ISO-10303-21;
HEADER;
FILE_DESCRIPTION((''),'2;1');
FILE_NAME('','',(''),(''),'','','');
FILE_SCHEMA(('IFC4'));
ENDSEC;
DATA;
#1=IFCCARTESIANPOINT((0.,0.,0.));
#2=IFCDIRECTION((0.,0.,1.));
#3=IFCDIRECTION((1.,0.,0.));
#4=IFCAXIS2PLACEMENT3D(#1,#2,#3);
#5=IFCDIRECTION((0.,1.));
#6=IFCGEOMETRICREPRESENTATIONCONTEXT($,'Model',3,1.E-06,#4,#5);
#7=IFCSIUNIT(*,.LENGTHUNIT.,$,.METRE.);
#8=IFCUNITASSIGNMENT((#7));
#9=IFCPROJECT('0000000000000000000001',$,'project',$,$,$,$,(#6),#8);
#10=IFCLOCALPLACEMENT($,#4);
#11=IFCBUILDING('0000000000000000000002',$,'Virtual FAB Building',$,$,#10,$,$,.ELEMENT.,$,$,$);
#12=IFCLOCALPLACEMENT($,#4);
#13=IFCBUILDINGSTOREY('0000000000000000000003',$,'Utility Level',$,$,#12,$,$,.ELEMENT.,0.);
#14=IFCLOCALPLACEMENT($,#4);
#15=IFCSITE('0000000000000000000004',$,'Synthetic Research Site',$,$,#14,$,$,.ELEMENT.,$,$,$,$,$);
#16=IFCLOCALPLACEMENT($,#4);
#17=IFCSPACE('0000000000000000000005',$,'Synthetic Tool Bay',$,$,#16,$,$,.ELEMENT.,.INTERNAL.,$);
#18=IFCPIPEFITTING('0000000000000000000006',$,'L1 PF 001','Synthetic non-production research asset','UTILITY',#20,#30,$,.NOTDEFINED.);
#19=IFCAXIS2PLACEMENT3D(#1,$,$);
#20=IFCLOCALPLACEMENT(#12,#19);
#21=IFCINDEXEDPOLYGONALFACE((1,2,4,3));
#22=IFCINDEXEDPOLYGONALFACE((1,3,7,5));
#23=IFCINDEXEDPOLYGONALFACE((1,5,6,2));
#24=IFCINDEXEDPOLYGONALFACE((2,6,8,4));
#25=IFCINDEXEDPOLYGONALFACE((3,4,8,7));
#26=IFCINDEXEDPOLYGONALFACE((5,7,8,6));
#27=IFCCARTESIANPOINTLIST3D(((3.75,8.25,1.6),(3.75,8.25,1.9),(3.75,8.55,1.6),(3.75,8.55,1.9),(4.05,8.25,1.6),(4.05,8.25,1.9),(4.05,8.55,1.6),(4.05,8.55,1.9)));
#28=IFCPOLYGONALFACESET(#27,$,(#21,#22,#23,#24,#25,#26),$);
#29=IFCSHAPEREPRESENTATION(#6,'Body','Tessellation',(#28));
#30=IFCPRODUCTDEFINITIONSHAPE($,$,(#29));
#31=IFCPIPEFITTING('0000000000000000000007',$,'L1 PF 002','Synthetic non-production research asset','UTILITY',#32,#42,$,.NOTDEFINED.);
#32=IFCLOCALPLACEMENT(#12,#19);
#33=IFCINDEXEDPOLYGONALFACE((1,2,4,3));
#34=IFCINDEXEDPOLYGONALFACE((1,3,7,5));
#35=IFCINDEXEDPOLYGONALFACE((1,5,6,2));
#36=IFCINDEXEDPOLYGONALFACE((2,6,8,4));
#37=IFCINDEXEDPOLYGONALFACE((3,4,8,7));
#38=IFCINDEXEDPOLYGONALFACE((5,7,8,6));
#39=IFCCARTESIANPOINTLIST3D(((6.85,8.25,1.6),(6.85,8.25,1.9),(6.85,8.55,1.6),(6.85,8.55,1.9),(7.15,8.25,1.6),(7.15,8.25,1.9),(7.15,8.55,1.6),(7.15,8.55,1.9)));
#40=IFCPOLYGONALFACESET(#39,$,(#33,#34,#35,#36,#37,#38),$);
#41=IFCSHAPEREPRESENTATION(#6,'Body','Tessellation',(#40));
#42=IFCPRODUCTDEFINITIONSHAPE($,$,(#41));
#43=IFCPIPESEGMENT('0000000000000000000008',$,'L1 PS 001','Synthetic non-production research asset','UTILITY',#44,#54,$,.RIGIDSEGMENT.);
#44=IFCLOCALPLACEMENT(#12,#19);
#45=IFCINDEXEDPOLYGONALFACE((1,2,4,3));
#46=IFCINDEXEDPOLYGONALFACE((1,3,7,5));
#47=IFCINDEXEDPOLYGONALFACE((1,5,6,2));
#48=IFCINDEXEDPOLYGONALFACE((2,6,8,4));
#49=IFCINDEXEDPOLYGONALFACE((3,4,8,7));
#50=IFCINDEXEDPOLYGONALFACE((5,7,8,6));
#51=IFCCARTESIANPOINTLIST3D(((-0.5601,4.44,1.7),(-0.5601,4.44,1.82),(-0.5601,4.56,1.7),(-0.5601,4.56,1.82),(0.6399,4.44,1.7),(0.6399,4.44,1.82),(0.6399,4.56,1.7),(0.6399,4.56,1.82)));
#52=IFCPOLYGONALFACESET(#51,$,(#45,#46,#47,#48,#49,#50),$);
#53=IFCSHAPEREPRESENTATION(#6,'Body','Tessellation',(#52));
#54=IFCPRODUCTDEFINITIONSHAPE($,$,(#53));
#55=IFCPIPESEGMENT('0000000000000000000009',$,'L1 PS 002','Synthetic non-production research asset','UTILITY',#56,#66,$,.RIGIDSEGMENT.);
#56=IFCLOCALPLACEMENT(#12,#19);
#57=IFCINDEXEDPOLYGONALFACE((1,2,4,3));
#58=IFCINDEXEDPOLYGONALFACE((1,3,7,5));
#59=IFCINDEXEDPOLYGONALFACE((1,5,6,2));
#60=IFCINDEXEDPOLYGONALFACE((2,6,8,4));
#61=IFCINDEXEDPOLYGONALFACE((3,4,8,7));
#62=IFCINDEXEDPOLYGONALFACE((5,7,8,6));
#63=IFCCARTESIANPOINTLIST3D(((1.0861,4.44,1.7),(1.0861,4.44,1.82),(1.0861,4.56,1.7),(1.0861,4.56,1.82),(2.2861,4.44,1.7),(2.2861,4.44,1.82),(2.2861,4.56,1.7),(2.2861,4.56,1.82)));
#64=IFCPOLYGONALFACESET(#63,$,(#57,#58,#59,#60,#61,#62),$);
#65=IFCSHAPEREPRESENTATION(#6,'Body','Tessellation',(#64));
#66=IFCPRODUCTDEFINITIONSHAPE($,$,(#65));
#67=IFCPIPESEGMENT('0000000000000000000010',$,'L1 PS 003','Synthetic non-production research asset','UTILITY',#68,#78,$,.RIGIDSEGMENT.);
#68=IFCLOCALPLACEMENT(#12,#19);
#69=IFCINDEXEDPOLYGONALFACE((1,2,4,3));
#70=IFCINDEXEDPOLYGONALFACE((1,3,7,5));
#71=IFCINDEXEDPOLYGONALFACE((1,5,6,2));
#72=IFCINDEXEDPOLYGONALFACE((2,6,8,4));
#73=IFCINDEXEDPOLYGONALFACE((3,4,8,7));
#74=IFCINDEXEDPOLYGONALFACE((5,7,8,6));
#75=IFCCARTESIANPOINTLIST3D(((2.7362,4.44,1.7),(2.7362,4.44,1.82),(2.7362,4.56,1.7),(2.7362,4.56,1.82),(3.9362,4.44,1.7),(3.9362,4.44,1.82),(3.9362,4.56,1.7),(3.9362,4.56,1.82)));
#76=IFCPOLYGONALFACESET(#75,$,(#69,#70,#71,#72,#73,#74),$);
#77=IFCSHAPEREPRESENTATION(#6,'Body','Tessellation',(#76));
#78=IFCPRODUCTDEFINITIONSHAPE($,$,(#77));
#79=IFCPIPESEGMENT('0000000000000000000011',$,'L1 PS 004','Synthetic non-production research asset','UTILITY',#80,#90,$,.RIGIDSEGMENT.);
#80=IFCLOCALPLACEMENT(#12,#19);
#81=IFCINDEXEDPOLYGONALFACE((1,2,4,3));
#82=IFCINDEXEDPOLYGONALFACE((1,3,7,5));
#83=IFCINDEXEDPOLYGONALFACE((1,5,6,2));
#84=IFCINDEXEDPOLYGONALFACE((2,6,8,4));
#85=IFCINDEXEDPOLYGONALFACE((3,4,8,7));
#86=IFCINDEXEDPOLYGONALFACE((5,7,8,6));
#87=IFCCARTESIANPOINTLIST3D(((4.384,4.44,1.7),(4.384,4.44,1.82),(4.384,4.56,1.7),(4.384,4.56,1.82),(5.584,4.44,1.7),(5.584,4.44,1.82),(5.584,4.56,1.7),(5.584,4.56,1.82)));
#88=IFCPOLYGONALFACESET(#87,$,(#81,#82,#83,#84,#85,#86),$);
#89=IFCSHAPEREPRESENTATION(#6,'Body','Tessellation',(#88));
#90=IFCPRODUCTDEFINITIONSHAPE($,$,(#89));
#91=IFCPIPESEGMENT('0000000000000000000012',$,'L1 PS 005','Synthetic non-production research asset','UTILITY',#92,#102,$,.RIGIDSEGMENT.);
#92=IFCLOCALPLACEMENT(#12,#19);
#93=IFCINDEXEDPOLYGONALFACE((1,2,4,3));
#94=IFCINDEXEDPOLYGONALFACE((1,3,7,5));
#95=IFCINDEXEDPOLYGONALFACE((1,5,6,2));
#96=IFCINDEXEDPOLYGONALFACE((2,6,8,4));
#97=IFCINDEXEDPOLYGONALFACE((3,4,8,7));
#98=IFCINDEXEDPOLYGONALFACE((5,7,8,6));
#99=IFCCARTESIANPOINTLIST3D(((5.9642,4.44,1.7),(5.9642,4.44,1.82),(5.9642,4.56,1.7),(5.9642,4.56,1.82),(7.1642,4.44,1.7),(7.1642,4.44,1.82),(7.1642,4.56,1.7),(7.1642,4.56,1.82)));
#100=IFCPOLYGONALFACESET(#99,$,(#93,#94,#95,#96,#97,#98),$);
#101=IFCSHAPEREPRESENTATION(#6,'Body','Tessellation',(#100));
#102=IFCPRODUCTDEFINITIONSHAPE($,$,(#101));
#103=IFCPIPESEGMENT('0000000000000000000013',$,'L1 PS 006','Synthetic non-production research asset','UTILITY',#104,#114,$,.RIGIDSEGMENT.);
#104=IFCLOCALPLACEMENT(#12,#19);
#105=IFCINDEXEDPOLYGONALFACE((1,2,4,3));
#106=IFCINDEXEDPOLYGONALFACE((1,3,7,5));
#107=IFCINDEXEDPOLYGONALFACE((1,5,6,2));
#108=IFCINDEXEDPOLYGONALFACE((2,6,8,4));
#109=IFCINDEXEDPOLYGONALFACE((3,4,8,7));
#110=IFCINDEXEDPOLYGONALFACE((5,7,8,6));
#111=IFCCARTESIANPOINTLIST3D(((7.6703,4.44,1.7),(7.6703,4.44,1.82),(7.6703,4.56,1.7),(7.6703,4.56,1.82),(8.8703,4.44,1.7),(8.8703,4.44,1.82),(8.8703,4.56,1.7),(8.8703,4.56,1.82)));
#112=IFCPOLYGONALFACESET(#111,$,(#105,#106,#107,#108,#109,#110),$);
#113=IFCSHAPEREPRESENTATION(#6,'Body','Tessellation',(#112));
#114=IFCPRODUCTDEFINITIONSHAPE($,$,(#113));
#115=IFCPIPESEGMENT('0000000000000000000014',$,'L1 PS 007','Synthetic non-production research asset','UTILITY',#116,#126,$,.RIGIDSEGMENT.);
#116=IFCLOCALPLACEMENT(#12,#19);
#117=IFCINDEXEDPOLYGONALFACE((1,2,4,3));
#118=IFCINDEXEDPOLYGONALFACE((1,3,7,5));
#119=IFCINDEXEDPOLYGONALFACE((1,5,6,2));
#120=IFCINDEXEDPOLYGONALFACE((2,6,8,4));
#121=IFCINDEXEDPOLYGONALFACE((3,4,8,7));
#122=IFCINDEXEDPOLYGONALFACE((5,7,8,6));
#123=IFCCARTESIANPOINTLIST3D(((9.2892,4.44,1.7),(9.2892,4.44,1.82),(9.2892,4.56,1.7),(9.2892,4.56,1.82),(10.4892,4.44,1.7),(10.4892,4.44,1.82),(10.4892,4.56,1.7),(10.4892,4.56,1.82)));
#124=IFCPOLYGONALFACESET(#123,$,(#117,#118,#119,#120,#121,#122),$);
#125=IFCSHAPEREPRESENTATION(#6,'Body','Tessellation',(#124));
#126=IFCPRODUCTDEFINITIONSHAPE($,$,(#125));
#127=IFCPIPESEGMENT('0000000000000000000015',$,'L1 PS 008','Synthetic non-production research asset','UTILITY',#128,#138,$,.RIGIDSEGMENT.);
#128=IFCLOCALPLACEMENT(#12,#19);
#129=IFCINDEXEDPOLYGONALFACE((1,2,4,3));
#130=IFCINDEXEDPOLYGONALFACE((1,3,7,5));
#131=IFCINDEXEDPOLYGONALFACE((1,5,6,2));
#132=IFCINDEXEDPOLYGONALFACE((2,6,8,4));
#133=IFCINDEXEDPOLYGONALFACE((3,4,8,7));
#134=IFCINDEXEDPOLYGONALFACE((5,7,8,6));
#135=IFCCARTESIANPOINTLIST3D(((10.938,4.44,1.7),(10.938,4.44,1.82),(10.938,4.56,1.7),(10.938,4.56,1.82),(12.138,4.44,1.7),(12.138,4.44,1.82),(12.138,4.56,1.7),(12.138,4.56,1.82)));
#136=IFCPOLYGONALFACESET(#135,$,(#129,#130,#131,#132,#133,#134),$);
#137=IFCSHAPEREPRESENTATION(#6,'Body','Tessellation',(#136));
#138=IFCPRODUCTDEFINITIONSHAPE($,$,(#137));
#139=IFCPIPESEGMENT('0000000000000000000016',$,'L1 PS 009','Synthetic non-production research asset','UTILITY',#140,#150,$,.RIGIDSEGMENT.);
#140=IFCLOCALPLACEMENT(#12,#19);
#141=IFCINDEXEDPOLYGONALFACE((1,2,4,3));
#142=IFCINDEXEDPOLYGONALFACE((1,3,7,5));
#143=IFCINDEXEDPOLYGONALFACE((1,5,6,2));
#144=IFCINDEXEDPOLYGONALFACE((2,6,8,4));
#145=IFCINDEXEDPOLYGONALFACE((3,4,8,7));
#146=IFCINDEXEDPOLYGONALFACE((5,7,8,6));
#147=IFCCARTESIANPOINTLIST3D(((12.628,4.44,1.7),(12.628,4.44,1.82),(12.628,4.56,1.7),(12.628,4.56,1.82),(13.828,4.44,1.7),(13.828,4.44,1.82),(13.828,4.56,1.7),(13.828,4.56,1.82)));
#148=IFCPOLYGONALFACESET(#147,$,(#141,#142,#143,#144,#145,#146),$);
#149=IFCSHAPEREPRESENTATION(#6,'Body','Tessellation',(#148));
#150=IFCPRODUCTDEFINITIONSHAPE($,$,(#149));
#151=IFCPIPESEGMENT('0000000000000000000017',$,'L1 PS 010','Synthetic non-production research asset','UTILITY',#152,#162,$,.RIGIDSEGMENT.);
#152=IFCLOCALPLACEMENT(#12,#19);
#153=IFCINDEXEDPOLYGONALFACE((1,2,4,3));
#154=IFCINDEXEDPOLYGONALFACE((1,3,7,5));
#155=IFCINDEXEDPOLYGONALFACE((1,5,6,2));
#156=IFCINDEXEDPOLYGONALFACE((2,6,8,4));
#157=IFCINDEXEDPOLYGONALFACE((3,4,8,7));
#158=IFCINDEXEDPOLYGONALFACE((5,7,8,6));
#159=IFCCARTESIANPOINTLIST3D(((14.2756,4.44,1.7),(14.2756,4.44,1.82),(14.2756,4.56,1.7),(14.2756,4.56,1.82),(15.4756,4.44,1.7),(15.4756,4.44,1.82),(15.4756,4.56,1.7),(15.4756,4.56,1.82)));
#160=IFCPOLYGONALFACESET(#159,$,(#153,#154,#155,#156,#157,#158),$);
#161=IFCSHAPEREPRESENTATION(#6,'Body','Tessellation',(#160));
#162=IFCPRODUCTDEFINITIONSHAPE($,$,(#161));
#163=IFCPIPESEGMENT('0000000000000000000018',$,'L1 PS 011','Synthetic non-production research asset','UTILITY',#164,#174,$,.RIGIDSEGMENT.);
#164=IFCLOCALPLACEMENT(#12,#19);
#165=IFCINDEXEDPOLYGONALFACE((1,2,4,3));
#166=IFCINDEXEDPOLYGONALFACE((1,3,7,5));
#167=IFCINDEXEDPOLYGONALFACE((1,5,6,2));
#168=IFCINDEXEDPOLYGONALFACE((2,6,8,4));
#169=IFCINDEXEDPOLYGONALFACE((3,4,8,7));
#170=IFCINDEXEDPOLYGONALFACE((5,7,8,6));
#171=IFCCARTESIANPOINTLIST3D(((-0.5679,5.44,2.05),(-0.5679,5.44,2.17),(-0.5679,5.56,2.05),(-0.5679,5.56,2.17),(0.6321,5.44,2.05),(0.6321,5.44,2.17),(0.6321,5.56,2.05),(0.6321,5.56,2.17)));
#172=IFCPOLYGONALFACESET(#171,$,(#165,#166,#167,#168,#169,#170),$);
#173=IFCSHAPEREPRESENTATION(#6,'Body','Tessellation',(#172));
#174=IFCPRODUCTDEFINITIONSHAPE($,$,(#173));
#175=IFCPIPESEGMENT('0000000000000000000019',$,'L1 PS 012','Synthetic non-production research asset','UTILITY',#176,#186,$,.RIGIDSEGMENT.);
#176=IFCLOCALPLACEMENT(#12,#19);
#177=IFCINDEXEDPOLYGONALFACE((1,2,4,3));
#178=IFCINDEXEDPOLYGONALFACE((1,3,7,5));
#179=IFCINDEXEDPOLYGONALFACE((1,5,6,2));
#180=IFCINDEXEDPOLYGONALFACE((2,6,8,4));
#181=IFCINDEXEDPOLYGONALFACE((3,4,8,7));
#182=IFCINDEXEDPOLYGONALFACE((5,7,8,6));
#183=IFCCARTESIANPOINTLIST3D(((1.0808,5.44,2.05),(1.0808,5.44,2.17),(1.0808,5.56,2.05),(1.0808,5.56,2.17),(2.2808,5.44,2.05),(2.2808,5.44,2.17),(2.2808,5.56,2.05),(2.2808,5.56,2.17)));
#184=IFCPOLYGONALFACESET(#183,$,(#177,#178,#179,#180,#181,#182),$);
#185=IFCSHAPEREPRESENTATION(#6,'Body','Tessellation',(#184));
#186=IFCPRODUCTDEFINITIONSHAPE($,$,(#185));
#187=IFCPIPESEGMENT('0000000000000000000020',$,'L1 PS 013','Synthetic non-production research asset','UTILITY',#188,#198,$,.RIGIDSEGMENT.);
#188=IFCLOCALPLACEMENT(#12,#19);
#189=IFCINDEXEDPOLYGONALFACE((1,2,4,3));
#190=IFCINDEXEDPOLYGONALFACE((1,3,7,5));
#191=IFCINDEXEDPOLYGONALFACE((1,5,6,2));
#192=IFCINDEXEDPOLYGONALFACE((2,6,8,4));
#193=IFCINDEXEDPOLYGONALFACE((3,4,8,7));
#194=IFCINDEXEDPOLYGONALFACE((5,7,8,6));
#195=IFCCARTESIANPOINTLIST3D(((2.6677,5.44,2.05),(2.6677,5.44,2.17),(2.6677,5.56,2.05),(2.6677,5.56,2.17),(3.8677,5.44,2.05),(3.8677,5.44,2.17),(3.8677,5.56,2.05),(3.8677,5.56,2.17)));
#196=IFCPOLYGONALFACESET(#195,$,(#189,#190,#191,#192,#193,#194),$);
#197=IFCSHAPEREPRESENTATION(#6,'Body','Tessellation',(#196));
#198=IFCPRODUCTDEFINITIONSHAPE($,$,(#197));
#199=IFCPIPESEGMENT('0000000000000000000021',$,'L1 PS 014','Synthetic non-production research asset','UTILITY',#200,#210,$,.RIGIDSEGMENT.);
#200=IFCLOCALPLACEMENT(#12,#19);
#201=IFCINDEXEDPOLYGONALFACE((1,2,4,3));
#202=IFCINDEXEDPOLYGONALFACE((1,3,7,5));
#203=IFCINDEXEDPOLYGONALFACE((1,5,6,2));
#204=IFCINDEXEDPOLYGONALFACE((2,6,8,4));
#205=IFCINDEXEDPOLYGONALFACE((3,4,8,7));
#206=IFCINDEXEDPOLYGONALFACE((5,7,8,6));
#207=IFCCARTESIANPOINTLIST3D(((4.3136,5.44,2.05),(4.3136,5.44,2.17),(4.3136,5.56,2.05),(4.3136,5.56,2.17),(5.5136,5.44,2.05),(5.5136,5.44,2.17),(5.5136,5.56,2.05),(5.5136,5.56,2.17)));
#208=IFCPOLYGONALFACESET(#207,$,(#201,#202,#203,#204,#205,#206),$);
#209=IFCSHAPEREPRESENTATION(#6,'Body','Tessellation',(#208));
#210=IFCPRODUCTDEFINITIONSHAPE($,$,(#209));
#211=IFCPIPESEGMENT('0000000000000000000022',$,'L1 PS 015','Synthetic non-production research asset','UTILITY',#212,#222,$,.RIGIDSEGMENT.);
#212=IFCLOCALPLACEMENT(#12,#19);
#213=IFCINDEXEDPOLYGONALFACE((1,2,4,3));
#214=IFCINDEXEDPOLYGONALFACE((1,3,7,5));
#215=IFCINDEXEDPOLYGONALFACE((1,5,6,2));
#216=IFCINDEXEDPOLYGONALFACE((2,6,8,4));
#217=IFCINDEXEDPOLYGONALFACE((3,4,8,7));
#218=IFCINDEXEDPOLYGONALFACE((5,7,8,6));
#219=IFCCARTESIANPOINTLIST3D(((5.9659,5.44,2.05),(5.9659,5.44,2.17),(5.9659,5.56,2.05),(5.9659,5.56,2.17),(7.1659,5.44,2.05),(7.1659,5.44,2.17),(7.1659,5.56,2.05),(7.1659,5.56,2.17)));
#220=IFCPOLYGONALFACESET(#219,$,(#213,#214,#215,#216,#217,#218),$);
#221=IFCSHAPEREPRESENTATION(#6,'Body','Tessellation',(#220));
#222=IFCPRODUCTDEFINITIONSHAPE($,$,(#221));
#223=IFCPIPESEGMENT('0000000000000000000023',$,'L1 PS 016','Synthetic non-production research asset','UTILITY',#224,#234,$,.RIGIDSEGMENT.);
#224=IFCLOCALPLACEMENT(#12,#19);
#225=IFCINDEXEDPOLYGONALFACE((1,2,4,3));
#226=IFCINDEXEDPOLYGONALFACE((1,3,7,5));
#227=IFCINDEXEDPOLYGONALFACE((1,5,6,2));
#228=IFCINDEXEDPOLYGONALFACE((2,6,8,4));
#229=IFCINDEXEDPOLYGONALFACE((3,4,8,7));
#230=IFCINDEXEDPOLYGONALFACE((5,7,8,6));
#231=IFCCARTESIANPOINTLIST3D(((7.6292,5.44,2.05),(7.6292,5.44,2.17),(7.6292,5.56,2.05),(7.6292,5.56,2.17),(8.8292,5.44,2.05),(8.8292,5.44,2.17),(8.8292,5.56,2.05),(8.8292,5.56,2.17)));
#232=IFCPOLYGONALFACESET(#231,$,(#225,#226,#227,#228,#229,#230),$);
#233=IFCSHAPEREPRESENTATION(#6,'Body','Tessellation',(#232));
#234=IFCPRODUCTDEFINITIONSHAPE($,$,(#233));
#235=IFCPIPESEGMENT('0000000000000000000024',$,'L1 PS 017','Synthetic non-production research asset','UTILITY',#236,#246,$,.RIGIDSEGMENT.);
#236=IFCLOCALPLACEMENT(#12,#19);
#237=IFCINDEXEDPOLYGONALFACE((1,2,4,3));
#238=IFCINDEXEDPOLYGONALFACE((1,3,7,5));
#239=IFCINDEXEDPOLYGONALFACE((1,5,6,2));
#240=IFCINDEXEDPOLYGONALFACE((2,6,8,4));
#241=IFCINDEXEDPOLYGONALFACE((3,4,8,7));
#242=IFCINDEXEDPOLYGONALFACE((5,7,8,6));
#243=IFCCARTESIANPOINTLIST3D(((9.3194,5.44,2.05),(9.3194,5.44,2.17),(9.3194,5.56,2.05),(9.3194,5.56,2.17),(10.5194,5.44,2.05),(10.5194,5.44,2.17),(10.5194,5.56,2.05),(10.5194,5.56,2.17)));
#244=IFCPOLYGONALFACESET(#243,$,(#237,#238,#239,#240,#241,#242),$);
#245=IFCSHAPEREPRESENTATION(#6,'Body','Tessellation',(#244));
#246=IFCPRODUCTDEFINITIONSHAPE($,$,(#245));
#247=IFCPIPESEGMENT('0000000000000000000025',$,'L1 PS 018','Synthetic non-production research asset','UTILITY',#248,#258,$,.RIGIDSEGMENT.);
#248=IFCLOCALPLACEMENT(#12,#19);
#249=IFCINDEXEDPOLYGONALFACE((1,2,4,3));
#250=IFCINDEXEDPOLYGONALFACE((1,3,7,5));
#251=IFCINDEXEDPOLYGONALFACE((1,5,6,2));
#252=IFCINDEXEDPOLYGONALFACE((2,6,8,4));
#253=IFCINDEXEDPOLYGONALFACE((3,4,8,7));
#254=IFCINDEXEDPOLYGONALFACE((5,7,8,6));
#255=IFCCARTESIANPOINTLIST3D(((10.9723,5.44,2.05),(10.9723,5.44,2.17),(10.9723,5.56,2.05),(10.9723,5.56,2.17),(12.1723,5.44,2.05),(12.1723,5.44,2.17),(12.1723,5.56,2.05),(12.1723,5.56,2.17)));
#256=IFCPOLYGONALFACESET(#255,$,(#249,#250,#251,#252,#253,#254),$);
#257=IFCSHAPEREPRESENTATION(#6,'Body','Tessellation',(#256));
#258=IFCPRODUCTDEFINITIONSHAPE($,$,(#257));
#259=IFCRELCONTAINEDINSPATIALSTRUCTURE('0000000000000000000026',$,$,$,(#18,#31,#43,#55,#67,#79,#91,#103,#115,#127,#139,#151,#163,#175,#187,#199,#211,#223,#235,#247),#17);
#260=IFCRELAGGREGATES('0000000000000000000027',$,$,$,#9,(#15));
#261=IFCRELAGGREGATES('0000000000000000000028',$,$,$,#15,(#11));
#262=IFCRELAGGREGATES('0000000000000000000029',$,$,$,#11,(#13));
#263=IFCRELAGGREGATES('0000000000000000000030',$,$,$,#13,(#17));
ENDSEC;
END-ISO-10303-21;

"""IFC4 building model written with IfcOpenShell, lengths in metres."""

from ifc_helpers import new_model, si_unit, direction, frame, origin_with_axes, origin_2d_with_axis, place, context, project, spatial, rectangle, extrude, element, save


model = new_model("IFC4")

# Units and contexts
model_context = context("Model", 3, precision=1e-06, world=origin_with_axes(), true_north=direction((0.0, 1.0)))
ifc_project = project(units=[si_unit("LENGTHUNIT", "METRE")], contexts=[model_context])

# Site, building, storey, space
site_placement = place(None, origin_with_axes())
site = spatial("IfcSite", under=ifc_project, at=site_placement, Name="Synthetic Research Site", CompositionType="ELEMENT")
building_placement = place(None, origin_with_axes())
building = spatial("IfcBuilding", under=site, at=building_placement, Name="Virtual FAB Building", CompositionType="ELEMENT")
storey_placement = place(None, origin_with_axes())
storey = spatial("IfcBuildingStorey", under=building, at=storey_placement, Name="Utility Level", CompositionType="ELEMENT", Elevation=0.0)
space_placement = place(None, origin_with_axes())
space = spatial("IfcSpace", under=storey, at=space_placement, Name="Synthetic Tool Bay", CompositionType="ELEMENT", PredefinedType="INTERNAL")

# Pipe fittings
for number, where, z_axis, x_axis, name in (
    (1, (3.9, 8.4, 1.6), (0.0, 0.0, 1.0), (1.0, 0.0, 0.0), "L1 PF 001"),
    (2, (7.0, 8.4, 1.6), (0.0, 0.0, 1.0), (1.0, 0.0, 0.0), "L1 PF 002"),
):
    element("IfcPipeFitting", number, at=place(None, frame(where, z_axis=z_axis, x_axis=x_axis)), inside=space, Name=name, Description="Synthetic non-production research asset", ObjectType="UTILITY", PredefinedType="NOTDEFINED", context=model_context, shape_type="SweptSolid", body=[
        extrude(rectangle(XDim=0.3, YDim=0.3, at=origin_2d_with_axis()), origin_with_axes(), (0.0, 0.0, 1.0), 0.3),
    ])

# Pipe segments
for number, where, z_axis, x_axis, name in (
    (3, (0.0399, 4.5, 1.7), (0.0, 0.0, 1.0), (1.0, 0.0, 0.0), "L1 PS 001"),
    (4, (1.6861, 4.5, 1.7), (0.0, 0.0, 1.0), (1.0, 0.0, 0.0), "L1 PS 002"),
    (5, (3.3362, 4.5, 1.7), (0.0, 0.0, 1.0), (1.0, 0.0, 0.0), "L1 PS 003"),
    (6, (4.984, 4.5, 1.7), (0.0, 0.0, 1.0), (1.0, 0.0, 0.0), "L1 PS 004"),
    (7, (6.5642, 4.5, 1.7), (0.0, 0.0, 1.0), (1.0, 0.0, 0.0), "L1 PS 005"),
    (8, (8.2703, 4.5, 1.7), (0.0, 0.0, 1.0), (1.0, 0.0, 0.0), "L1 PS 006"),
    (9, (9.8892, 4.5, 1.7), (0.0, 0.0, 1.0), (1.0, 0.0, 0.0), "L1 PS 007"),
    (10, (11.538, 4.5, 1.7), (0.0, 0.0, 1.0), (1.0, 0.0, 0.0), "L1 PS 008"),
    (11, (13.228, 4.5, 1.7), (0.0, 0.0, 1.0), (1.0, 0.0, 0.0), "L1 PS 009"),
    (12, (14.8756, 4.5, 1.7), (0.0, 0.0, 1.0), (1.0, 0.0, 0.0), "L1 PS 010"),
    (13, (0.0321, 5.5, 2.05), (0.0, 0.0, 1.0), (1.0, 0.0, 0.0), "L1 PS 011"),
    (14, (1.6808, 5.5, 2.05), (0.0, 0.0, 1.0), (1.0, 0.0, 0.0), "L1 PS 012"),
    (15, (3.2677, 5.5, 2.05), (0.0, 0.0, 1.0), (1.0, 0.0, 0.0), "L1 PS 013"),
    (16, (4.9136, 5.5, 2.05), (0.0, 0.0, 1.0), (1.0, 0.0, 0.0), "L1 PS 014"),
    (17, (6.5659, 5.5, 2.05), (0.0, 0.0, 1.0), (1.0, 0.0, 0.0), "L1 PS 015"),
    (18, (8.2292, 5.5, 2.05), (0.0, 0.0, 1.0), (1.0, 0.0, 0.0), "L1 PS 016"),
    (19, (9.9194, 5.5, 2.05), (0.0, 0.0, 1.0), (1.0, 0.0, 0.0), "L1 PS 017"),
    (20, (11.5723, 5.5, 2.05), (0.0, 0.0, 1.0), (1.0, 0.0, 0.0), "L1 PS 018"),
):
    element("IfcPipeSegment", number, at=place(None, frame(where, z_axis=z_axis, x_axis=x_axis)), inside=space, Name=name, Description="Synthetic non-production research asset", ObjectType="UTILITY", PredefinedType="RIGIDSEGMENT", context=model_context, shape_type="SweptSolid", body=[
        extrude(rectangle(XDim=1.2, YDim=0.12, at=origin_2d_with_axis()), origin_with_axes(), (0.0, 0.0, 1.0), 0.12),
    ])

save(model, "model.ifc")
